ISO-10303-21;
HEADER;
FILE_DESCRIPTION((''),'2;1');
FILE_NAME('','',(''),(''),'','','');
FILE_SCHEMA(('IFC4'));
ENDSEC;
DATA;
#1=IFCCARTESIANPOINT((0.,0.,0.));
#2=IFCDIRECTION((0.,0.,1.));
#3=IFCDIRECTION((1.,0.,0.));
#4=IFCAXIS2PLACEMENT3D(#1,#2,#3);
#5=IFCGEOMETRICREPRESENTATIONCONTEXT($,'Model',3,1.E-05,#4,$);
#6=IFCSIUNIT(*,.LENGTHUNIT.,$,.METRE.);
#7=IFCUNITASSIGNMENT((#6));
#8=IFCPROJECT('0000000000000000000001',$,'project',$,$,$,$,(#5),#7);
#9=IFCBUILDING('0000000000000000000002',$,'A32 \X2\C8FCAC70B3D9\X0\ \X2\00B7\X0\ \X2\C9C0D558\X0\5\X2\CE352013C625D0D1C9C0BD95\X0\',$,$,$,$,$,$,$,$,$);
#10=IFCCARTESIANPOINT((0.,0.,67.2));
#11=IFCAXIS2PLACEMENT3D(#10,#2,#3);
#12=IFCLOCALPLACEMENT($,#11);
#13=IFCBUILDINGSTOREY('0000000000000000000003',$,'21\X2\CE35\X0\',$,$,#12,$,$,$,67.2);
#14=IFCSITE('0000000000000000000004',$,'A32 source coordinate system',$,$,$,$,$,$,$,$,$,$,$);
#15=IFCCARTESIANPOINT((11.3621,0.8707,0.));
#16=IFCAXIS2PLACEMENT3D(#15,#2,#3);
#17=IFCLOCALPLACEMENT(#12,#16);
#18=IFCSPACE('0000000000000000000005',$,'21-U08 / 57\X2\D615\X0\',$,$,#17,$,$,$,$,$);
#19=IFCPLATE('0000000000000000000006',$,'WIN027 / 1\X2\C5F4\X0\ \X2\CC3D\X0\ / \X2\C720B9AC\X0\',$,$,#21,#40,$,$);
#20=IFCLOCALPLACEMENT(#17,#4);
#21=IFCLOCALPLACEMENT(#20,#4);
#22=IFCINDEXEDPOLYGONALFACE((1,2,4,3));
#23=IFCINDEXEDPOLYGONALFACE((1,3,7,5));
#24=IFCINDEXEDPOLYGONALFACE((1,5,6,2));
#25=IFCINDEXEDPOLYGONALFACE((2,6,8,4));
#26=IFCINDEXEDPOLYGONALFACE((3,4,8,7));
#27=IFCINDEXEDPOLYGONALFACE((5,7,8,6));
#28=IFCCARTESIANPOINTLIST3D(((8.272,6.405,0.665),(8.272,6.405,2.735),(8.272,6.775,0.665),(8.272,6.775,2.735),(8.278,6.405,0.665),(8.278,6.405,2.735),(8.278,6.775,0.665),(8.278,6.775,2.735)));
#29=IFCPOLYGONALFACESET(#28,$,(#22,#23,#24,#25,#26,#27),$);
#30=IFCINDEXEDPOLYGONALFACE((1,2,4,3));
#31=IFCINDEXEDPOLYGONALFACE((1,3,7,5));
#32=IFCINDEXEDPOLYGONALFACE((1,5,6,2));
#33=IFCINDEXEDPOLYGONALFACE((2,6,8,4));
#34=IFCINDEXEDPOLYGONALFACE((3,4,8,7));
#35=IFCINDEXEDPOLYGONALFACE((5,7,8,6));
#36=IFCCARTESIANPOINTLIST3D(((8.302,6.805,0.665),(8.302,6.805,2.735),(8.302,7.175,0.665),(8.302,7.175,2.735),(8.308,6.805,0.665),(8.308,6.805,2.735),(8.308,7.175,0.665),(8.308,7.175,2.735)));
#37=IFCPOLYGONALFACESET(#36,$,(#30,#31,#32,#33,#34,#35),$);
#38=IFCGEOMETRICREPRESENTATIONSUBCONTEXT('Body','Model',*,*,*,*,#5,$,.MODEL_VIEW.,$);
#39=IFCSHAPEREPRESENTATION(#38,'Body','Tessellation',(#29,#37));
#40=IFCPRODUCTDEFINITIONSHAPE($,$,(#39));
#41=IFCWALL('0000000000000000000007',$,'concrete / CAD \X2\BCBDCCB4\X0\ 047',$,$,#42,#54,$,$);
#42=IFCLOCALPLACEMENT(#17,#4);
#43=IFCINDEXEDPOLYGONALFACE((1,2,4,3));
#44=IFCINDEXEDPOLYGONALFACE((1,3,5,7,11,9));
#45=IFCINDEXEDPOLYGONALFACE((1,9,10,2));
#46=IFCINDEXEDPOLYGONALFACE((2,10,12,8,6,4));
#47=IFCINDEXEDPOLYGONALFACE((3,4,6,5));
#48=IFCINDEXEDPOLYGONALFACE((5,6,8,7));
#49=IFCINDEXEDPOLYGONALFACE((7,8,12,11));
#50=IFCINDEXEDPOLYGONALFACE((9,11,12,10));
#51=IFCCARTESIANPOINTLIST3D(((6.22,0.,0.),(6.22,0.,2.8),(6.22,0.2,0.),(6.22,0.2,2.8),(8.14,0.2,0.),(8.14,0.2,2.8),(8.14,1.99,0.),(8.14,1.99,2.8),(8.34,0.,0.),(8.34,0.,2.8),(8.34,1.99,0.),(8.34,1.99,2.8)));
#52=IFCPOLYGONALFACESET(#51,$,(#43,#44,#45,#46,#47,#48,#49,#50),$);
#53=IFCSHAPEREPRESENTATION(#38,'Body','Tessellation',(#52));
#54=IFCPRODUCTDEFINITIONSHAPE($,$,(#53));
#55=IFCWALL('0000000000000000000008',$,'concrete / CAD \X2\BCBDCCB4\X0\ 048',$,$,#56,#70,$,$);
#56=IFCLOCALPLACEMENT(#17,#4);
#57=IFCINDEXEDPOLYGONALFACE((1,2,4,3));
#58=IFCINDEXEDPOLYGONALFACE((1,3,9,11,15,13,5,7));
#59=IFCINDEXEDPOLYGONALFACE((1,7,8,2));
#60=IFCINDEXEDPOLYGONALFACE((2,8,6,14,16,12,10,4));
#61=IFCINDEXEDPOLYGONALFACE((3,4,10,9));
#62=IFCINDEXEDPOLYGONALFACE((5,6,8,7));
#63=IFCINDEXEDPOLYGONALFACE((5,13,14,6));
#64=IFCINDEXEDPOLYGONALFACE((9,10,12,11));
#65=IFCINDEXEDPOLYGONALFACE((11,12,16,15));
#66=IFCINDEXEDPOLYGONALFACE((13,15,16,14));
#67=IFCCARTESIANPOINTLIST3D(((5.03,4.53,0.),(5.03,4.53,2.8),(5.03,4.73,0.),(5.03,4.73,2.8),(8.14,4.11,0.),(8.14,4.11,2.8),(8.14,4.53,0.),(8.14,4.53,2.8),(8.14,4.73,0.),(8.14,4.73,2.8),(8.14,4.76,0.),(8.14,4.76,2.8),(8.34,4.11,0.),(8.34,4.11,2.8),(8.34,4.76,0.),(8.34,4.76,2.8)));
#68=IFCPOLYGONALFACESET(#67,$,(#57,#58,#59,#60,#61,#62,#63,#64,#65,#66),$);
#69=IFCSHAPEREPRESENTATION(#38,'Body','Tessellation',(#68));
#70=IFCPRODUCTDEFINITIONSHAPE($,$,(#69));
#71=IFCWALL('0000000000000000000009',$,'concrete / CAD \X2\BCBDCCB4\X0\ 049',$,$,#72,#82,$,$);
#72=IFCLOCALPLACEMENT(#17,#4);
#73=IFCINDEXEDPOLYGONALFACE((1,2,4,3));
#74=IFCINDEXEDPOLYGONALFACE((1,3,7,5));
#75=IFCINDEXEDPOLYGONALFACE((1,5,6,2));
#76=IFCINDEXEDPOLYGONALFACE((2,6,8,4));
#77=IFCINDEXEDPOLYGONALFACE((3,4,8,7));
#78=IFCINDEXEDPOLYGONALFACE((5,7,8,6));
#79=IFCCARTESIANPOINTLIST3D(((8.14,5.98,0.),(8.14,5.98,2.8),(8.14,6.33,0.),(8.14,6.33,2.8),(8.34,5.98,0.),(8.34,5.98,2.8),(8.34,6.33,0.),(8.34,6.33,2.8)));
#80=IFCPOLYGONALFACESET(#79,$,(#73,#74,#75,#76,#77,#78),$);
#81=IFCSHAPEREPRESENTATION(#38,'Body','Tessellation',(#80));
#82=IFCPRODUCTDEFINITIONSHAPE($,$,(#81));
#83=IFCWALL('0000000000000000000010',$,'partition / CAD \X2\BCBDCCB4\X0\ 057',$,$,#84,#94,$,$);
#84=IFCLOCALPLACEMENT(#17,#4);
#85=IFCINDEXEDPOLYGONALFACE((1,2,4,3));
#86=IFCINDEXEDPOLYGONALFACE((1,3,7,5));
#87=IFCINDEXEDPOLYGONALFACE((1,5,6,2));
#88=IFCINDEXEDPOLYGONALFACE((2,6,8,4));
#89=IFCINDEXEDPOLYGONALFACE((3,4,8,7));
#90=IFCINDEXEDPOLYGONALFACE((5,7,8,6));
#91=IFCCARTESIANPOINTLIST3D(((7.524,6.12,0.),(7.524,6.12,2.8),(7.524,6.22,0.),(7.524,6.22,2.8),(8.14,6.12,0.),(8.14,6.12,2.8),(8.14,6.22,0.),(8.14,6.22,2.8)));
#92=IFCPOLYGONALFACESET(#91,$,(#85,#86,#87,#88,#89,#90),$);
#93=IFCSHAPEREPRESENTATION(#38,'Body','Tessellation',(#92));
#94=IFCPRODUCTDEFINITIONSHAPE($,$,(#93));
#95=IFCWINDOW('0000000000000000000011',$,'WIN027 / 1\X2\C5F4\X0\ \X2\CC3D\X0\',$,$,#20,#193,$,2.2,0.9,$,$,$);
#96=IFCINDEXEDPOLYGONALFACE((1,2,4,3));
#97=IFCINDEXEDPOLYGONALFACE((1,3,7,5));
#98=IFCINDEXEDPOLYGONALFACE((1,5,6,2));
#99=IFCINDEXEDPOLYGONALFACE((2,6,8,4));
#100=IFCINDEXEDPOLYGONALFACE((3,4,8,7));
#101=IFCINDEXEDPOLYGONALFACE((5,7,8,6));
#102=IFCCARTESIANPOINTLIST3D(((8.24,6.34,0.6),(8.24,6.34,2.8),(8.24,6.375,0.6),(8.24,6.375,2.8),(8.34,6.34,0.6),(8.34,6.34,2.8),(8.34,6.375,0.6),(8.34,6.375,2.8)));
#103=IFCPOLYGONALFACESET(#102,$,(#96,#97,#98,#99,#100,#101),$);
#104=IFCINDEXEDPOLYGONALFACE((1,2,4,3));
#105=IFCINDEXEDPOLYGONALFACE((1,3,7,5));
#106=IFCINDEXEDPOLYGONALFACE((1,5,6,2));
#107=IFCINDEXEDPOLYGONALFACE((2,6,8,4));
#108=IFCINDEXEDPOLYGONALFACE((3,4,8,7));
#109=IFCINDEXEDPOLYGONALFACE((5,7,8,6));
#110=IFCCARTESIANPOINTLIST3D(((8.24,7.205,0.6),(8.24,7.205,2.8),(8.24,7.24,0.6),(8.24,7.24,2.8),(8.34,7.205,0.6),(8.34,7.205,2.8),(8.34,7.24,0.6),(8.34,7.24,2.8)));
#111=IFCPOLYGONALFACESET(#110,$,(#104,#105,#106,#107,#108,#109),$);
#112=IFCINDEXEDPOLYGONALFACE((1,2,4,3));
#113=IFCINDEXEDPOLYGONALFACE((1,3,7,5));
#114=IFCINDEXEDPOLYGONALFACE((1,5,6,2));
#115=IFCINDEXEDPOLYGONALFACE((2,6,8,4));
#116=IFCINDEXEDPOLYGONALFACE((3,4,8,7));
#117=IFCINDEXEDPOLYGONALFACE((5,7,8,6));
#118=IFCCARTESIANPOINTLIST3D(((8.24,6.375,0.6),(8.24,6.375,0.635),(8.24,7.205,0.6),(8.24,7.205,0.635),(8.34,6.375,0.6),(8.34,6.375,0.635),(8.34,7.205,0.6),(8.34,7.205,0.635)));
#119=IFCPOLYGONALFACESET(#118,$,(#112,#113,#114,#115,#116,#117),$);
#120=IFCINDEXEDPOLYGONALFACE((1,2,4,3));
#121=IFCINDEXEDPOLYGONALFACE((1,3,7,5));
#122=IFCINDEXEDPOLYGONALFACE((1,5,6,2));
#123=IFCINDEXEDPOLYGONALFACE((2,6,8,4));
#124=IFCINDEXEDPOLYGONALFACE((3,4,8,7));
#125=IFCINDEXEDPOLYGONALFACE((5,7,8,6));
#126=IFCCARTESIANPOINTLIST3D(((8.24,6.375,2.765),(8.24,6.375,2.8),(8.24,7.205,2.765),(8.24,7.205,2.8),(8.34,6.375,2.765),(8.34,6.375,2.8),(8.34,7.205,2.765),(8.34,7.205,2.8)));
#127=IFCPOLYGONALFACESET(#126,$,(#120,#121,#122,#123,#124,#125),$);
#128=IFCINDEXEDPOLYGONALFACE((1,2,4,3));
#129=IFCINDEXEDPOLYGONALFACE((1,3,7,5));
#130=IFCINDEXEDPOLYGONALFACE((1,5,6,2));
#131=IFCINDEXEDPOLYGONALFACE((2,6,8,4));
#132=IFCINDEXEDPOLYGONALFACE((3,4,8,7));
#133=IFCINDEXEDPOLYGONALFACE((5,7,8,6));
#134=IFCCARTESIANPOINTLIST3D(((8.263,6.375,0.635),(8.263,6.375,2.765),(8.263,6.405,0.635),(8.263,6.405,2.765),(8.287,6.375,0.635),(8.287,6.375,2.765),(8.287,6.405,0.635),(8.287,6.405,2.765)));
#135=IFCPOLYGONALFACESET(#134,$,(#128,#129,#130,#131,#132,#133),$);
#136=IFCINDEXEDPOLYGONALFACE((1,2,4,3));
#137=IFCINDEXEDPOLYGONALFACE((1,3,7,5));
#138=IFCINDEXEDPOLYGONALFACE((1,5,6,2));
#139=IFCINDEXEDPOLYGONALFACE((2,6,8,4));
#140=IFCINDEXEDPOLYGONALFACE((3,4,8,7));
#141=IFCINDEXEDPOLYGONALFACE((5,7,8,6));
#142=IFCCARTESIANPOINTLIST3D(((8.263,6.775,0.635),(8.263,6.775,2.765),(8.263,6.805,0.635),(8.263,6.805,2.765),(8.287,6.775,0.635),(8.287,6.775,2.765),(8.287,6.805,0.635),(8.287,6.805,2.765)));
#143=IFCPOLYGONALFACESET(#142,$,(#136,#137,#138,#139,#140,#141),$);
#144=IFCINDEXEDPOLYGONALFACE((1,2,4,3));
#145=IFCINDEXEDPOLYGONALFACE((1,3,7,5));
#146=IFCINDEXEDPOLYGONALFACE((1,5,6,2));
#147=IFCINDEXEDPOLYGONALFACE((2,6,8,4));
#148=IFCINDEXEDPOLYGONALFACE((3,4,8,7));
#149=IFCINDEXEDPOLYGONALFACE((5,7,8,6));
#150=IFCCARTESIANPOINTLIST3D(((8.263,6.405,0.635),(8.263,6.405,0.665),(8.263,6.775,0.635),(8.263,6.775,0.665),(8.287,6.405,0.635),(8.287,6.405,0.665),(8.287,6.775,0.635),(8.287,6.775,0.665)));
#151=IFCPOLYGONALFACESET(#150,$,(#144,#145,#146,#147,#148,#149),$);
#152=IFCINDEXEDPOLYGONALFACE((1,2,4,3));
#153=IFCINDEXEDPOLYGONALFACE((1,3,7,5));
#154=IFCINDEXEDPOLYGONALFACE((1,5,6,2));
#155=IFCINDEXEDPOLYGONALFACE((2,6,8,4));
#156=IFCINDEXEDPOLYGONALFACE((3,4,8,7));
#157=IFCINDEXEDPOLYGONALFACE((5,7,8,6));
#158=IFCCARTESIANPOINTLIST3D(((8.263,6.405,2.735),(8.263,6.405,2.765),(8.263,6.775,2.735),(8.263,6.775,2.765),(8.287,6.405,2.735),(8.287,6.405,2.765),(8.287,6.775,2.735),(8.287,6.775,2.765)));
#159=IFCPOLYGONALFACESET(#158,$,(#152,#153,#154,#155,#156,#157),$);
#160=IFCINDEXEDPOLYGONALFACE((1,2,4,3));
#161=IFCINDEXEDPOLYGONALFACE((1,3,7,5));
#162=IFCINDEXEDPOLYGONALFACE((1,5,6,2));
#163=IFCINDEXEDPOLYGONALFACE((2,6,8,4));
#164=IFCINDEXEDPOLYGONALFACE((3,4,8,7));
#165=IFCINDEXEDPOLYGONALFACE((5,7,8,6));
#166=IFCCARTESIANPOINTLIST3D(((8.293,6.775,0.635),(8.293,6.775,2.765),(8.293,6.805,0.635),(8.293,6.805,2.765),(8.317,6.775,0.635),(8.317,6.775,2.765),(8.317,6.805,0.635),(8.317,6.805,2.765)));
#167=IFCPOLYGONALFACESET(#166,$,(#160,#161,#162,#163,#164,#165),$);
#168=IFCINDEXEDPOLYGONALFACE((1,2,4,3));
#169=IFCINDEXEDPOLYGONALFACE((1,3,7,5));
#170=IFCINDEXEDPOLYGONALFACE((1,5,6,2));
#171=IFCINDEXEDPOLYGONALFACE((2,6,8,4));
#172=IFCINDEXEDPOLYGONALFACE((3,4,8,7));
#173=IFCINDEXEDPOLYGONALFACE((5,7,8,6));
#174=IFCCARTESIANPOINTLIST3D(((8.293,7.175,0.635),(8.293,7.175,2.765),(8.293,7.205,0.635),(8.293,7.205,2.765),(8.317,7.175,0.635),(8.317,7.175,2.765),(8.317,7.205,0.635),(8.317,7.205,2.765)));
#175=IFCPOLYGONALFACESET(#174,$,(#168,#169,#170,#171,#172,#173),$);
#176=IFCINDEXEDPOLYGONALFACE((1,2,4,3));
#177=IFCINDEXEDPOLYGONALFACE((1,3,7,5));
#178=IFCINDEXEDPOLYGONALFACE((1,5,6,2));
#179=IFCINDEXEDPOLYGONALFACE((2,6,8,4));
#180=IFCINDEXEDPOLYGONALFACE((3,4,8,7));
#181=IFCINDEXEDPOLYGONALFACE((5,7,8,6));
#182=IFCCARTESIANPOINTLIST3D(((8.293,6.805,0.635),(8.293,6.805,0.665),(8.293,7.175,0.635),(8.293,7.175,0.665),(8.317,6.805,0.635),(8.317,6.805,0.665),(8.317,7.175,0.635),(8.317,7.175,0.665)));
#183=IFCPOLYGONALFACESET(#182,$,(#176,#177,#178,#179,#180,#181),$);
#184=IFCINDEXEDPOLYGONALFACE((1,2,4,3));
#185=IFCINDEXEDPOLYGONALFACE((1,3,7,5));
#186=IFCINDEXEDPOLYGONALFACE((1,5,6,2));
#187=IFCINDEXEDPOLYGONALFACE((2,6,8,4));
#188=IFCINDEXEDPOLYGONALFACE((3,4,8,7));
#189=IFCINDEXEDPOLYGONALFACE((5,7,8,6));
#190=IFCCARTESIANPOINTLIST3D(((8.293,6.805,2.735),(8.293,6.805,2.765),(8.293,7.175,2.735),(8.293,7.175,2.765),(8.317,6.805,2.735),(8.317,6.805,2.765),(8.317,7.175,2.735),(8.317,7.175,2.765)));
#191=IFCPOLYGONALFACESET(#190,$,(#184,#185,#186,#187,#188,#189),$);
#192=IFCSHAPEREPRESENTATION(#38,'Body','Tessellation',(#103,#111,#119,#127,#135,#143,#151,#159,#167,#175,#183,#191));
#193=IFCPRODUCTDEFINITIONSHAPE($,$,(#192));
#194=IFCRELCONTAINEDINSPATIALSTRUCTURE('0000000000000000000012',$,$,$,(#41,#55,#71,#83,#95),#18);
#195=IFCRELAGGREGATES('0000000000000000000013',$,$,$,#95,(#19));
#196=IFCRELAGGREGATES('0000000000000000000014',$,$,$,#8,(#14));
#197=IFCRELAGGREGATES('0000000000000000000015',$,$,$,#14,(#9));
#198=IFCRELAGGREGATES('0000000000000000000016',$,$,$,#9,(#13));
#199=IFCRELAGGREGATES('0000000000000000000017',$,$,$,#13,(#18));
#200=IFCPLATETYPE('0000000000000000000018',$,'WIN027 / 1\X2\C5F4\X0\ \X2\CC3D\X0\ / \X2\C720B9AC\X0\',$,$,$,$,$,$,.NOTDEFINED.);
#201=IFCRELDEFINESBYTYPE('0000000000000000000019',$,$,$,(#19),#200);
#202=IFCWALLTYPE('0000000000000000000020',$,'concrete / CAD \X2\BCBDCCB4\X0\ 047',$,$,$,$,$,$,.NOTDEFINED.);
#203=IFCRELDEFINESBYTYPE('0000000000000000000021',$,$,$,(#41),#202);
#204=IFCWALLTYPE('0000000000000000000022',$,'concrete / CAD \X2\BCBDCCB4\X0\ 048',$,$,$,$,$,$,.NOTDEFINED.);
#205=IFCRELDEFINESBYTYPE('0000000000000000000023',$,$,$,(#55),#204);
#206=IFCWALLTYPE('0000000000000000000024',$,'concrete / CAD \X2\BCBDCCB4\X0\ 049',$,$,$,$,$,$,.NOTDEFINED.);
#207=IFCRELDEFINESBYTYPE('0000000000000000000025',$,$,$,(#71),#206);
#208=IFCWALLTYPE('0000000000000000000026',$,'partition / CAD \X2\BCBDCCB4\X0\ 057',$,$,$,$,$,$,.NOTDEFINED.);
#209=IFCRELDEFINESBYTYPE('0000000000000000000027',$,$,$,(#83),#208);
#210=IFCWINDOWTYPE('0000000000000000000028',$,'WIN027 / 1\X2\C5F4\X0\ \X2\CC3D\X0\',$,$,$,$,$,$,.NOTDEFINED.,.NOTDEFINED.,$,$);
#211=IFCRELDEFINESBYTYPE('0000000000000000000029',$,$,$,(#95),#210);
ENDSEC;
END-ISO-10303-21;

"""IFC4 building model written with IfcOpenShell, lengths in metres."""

from ifc_helpers import new_model, si_unit, frame, origin, origin_with_axes, place, context, subcontext, project, spatial, polyline, outline, extrude, source, transform, mapped, type_object, type_shapes, element, aggregate, save


model = new_model("IFC4")

# Units and contexts
model_context = context("Model", 3, precision=1e-05, world=origin_with_axes())
body_context = subcontext(model_context, "Body", "Model", "MODEL_VIEW")
ifc_project = project(units=[si_unit("LENGTHUNIT", "METRE")], contexts=[model_context])

# Plate
storey_placement = place(None, frame((0.0, 0.0, 67.2), z_axis=(0.0, 0.0, 1.0), x_axis=(1.0, 0.0, 0.0)))
space_placement = place(storey_placement, frame((11.3621, 0.8707, 0.0), z_axis=(0.0, 0.0, 1.0), x_axis=(1.0, 0.0, 0.0)))
plate_type_1 = type_object("IfcPlateType", Name="WIN027 / 1열 창 / 유리", PredefinedType="NOTDEFINED")
shared_shape_1 = source(origin(), body_context, "Body", "SweptSolid", [
    extrude(outline(polyline([(8.272, 6.405), (8.272, 6.775), (8.278, 6.775), (8.278, 6.405), (8.272, 6.405)])), frame((0.0, 0.0, 0.665)), (0.0, 0.0, 1.0), 2.07),
    extrude(outline(polyline([(8.302, 6.805), (8.302, 7.175), (8.308, 7.175), (8.308, 6.805), (8.302, 6.805)])), frame((0.0, 0.0, 0.665)), (0.0, 0.0, 1.0), 2.07),
])
type_shapes(plate_type_1, [shared_shape_1])
window_1_placement = place(space_placement, origin_with_axes())
plate_1_placement = place(window_1_placement, origin_with_axes())
plate_1 = element("IfcPlate", 1, at=plate_1_placement, type_object=plate_type_1, Name="WIN027 / 1열 창 / 유리", context=body_context, shape_type="MappedRepresentation", body=[
    mapped(shared_shape_1, transform((0.0, 0.0, 0.0), scale=1.0)),
])

# Site, building, storey, space
site = spatial("IfcSite", under=ifc_project, Name="A32 source coordinate system")
building = spatial("IfcBuilding", under=site, Name="A32 주거동 · 지하5층–옥탑지붕")
storey = spatial("IfcBuildingStorey", under=building, at=storey_placement, Name="21층", Elevation=67.2)
space = spatial("IfcSpace", under=storey, at=space_placement, Name="21-U08 / 57형")

# Walls
wall_type_1 = type_object("IfcWallType", Name="concrete / CAD 벽체 047", PredefinedType="NOTDEFINED")
shared_shape_2 = source(origin(), body_context, "Body", "SweptSolid", [
    extrude(outline(polyline([(8.14, 1.99), (8.34, 1.99), (8.34, 0.0), (6.22, 0.0), (6.22, 0.2), (8.14, 0.2), (8.14, 1.99)])), origin(), (0.0, 0.0, 1.0), 2.8),
])
type_shapes(wall_type_1, [shared_shape_2])
wall_1_placement = place(space_placement, origin_with_axes())
element("IfcWall", 2, at=wall_1_placement, inside=space, type_object=wall_type_1, Name="concrete / CAD 벽체 047", context=body_context, shape_type="MappedRepresentation", body=[
    mapped(shared_shape_2, transform((0.0, 0.0, 0.0), scale=1.0)),
])
wall_type_2 = type_object("IfcWallType", Name="concrete / CAD 벽체 048", PredefinedType="NOTDEFINED")
shared_shape_3 = source(origin(), body_context, "Body", "SweptSolid", [
    extrude(outline(polyline([(8.14, 4.53), (5.03, 4.53), (5.03, 4.73), (8.14, 4.73), (8.14, 4.76), (8.34, 4.76), (8.34, 4.11), (8.14, 4.11), (8.14, 4.53)])), origin(), (0.0, 0.0, 1.0), 2.8),
])
type_shapes(wall_type_2, [shared_shape_3])
wall_2_placement = place(space_placement, origin_with_axes())
element("IfcWall", 3, at=wall_2_placement, inside=space, type_object=wall_type_2, Name="concrete / CAD 벽체 048", context=body_context, shape_type="MappedRepresentation", body=[
    mapped(shared_shape_3, transform((0.0, 0.0, 0.0), scale=1.0)),
])
wall_type_3 = type_object("IfcWallType", Name="concrete / CAD 벽체 049", PredefinedType="NOTDEFINED")
shared_shape_4 = source(origin(), body_context, "Body", "SweptSolid", [
    extrude(outline(polyline([(8.34, 6.33), (8.34, 5.98), (8.14, 5.98), (8.14, 6.33), (8.34, 6.33)])), origin(), (0.0, 0.0, 1.0), 2.8),
])
type_shapes(wall_type_3, [shared_shape_4])
wall_3_placement = place(space_placement, origin_with_axes())
element("IfcWall", 4, at=wall_3_placement, inside=space, type_object=wall_type_3, Name="concrete / CAD 벽체 049", context=body_context, shape_type="MappedRepresentation", body=[
    mapped(shared_shape_4, transform((0.0, 0.0, 0.0), scale=1.0)),
])
wall_type_4 = type_object("IfcWallType", Name="partition / CAD 벽체 057", PredefinedType="NOTDEFINED")
shared_shape_5 = source(origin(), body_context, "Body", "SweptSolid", [
    extrude(outline(polyline([(7.524, 6.22), (8.14, 6.22), (8.14, 6.12), (7.524, 6.12), (7.524, 6.22)])), origin(), (0.0, 0.0, 1.0), 2.8),
])
type_shapes(wall_type_4, [shared_shape_5])
wall_4_placement = place(space_placement, origin_with_axes())
element("IfcWall", 5, at=wall_4_placement, inside=space, type_object=wall_type_4, Name="partition / CAD 벽체 057", context=body_context, shape_type="MappedRepresentation", body=[
    mapped(shared_shape_5, transform((0.0, 0.0, 0.0), scale=1.0)),
])

# Window
window_type_1 = type_object("IfcWindowType", Name="WIN027 / 1열 창", PartitioningType="NOTDEFINED", PredefinedType="NOTDEFINED")
shared_shape_6 = source(origin(), body_context, "Body", "SweptSolid", [
    extrude(outline(polyline([(8.24, 6.34), (8.24, 6.375), (8.34, 6.375), (8.34, 6.34), (8.24, 6.34)])), frame((0.0, 0.0, 0.6)), (0.0, 0.0, 1.0), 2.2),
    extrude(outline(polyline([(8.24, 7.205), (8.24, 7.24), (8.34, 7.24), (8.34, 7.205), (8.24, 7.205)])), frame((0.0, 0.0, 0.6)), (0.0, 0.0, 1.0), 2.2),
    extrude(outline(polyline([(8.24, 6.375), (8.24, 7.205), (8.34, 7.205), (8.34, 6.375), (8.24, 6.375)])), frame((0.0, 0.0, 0.6)), (0.0, 0.0, 1.0), 0.035),
    extrude(outline(polyline([(8.24, 6.375), (8.24, 7.205), (8.34, 7.205), (8.34, 6.375), (8.24, 6.375)])), frame((0.0, 0.0, 2.765)), (0.0, 0.0, 1.0), 0.035),
    extrude(outline(polyline([(8.263, 6.375), (8.263, 6.405), (8.287, 6.405), (8.287, 6.375), (8.263, 6.375)])), frame((0.0, 0.0, 0.635)), (0.0, 0.0, 1.0), 2.13),
    extrude(outline(polyline([(8.263, 6.775), (8.263, 6.805), (8.287, 6.805), (8.287, 6.775), (8.263, 6.775)])), frame((0.0, 0.0, 0.635)), (0.0, 0.0, 1.0), 2.13),
    extrude(outline(polyline([(8.263, 6.405), (8.263, 6.775), (8.287, 6.775), (8.287, 6.405), (8.263, 6.405)])), frame((0.0, 0.0, 0.635)), (0.0, 0.0, 1.0), 0.03),
    extrude(outline(polyline([(8.263, 6.405), (8.263, 6.775), (8.287, 6.775), (8.287, 6.405), (8.263, 6.405)])), frame((0.0, 0.0, 2.735)), (0.0, 0.0, 1.0), 0.03),
    extrude(outline(polyline([(8.293, 6.775), (8.293, 6.805), (8.317, 6.805), (8.317, 6.775), (8.293, 6.775)])), frame((0.0, 0.0, 0.635)), (0.0, 0.0, 1.0), 2.13),
    extrude(outline(polyline([(8.293, 7.175), (8.293, 7.205), (8.317, 7.205), (8.317, 7.175), (8.293, 7.175)])), frame((0.0, 0.0, 0.635)), (0.0, 0.0, 1.0), 2.13),
    extrude(outline(polyline([(8.293, 6.805), (8.293, 7.175), (8.317, 7.175), (8.317, 6.805), (8.293, 6.805)])), frame((0.0, 0.0, 0.635)), (0.0, 0.0, 1.0), 0.03),
    extrude(outline(polyline([(8.293, 6.805), (8.293, 7.175), (8.317, 7.175), (8.317, 6.805), (8.293, 6.805)])), frame((0.0, 0.0, 2.735)), (0.0, 0.0, 1.0), 0.03),
])
type_shapes(window_type_1, [shared_shape_6])
window_1 = element("IfcWindow", 6, at=window_1_placement, inside=space, type_object=window_type_1, Name="WIN027 / 1열 창", OverallHeight=2.2, OverallWidth=0.9, context=body_context, shape_type="MappedRepresentation", body=[
    mapped(shared_shape_6, transform((0.0, 0.0, 0.0), scale=1.0)),
])
aggregate(window_1, [plate_1])

save(model, "model.ifc")
